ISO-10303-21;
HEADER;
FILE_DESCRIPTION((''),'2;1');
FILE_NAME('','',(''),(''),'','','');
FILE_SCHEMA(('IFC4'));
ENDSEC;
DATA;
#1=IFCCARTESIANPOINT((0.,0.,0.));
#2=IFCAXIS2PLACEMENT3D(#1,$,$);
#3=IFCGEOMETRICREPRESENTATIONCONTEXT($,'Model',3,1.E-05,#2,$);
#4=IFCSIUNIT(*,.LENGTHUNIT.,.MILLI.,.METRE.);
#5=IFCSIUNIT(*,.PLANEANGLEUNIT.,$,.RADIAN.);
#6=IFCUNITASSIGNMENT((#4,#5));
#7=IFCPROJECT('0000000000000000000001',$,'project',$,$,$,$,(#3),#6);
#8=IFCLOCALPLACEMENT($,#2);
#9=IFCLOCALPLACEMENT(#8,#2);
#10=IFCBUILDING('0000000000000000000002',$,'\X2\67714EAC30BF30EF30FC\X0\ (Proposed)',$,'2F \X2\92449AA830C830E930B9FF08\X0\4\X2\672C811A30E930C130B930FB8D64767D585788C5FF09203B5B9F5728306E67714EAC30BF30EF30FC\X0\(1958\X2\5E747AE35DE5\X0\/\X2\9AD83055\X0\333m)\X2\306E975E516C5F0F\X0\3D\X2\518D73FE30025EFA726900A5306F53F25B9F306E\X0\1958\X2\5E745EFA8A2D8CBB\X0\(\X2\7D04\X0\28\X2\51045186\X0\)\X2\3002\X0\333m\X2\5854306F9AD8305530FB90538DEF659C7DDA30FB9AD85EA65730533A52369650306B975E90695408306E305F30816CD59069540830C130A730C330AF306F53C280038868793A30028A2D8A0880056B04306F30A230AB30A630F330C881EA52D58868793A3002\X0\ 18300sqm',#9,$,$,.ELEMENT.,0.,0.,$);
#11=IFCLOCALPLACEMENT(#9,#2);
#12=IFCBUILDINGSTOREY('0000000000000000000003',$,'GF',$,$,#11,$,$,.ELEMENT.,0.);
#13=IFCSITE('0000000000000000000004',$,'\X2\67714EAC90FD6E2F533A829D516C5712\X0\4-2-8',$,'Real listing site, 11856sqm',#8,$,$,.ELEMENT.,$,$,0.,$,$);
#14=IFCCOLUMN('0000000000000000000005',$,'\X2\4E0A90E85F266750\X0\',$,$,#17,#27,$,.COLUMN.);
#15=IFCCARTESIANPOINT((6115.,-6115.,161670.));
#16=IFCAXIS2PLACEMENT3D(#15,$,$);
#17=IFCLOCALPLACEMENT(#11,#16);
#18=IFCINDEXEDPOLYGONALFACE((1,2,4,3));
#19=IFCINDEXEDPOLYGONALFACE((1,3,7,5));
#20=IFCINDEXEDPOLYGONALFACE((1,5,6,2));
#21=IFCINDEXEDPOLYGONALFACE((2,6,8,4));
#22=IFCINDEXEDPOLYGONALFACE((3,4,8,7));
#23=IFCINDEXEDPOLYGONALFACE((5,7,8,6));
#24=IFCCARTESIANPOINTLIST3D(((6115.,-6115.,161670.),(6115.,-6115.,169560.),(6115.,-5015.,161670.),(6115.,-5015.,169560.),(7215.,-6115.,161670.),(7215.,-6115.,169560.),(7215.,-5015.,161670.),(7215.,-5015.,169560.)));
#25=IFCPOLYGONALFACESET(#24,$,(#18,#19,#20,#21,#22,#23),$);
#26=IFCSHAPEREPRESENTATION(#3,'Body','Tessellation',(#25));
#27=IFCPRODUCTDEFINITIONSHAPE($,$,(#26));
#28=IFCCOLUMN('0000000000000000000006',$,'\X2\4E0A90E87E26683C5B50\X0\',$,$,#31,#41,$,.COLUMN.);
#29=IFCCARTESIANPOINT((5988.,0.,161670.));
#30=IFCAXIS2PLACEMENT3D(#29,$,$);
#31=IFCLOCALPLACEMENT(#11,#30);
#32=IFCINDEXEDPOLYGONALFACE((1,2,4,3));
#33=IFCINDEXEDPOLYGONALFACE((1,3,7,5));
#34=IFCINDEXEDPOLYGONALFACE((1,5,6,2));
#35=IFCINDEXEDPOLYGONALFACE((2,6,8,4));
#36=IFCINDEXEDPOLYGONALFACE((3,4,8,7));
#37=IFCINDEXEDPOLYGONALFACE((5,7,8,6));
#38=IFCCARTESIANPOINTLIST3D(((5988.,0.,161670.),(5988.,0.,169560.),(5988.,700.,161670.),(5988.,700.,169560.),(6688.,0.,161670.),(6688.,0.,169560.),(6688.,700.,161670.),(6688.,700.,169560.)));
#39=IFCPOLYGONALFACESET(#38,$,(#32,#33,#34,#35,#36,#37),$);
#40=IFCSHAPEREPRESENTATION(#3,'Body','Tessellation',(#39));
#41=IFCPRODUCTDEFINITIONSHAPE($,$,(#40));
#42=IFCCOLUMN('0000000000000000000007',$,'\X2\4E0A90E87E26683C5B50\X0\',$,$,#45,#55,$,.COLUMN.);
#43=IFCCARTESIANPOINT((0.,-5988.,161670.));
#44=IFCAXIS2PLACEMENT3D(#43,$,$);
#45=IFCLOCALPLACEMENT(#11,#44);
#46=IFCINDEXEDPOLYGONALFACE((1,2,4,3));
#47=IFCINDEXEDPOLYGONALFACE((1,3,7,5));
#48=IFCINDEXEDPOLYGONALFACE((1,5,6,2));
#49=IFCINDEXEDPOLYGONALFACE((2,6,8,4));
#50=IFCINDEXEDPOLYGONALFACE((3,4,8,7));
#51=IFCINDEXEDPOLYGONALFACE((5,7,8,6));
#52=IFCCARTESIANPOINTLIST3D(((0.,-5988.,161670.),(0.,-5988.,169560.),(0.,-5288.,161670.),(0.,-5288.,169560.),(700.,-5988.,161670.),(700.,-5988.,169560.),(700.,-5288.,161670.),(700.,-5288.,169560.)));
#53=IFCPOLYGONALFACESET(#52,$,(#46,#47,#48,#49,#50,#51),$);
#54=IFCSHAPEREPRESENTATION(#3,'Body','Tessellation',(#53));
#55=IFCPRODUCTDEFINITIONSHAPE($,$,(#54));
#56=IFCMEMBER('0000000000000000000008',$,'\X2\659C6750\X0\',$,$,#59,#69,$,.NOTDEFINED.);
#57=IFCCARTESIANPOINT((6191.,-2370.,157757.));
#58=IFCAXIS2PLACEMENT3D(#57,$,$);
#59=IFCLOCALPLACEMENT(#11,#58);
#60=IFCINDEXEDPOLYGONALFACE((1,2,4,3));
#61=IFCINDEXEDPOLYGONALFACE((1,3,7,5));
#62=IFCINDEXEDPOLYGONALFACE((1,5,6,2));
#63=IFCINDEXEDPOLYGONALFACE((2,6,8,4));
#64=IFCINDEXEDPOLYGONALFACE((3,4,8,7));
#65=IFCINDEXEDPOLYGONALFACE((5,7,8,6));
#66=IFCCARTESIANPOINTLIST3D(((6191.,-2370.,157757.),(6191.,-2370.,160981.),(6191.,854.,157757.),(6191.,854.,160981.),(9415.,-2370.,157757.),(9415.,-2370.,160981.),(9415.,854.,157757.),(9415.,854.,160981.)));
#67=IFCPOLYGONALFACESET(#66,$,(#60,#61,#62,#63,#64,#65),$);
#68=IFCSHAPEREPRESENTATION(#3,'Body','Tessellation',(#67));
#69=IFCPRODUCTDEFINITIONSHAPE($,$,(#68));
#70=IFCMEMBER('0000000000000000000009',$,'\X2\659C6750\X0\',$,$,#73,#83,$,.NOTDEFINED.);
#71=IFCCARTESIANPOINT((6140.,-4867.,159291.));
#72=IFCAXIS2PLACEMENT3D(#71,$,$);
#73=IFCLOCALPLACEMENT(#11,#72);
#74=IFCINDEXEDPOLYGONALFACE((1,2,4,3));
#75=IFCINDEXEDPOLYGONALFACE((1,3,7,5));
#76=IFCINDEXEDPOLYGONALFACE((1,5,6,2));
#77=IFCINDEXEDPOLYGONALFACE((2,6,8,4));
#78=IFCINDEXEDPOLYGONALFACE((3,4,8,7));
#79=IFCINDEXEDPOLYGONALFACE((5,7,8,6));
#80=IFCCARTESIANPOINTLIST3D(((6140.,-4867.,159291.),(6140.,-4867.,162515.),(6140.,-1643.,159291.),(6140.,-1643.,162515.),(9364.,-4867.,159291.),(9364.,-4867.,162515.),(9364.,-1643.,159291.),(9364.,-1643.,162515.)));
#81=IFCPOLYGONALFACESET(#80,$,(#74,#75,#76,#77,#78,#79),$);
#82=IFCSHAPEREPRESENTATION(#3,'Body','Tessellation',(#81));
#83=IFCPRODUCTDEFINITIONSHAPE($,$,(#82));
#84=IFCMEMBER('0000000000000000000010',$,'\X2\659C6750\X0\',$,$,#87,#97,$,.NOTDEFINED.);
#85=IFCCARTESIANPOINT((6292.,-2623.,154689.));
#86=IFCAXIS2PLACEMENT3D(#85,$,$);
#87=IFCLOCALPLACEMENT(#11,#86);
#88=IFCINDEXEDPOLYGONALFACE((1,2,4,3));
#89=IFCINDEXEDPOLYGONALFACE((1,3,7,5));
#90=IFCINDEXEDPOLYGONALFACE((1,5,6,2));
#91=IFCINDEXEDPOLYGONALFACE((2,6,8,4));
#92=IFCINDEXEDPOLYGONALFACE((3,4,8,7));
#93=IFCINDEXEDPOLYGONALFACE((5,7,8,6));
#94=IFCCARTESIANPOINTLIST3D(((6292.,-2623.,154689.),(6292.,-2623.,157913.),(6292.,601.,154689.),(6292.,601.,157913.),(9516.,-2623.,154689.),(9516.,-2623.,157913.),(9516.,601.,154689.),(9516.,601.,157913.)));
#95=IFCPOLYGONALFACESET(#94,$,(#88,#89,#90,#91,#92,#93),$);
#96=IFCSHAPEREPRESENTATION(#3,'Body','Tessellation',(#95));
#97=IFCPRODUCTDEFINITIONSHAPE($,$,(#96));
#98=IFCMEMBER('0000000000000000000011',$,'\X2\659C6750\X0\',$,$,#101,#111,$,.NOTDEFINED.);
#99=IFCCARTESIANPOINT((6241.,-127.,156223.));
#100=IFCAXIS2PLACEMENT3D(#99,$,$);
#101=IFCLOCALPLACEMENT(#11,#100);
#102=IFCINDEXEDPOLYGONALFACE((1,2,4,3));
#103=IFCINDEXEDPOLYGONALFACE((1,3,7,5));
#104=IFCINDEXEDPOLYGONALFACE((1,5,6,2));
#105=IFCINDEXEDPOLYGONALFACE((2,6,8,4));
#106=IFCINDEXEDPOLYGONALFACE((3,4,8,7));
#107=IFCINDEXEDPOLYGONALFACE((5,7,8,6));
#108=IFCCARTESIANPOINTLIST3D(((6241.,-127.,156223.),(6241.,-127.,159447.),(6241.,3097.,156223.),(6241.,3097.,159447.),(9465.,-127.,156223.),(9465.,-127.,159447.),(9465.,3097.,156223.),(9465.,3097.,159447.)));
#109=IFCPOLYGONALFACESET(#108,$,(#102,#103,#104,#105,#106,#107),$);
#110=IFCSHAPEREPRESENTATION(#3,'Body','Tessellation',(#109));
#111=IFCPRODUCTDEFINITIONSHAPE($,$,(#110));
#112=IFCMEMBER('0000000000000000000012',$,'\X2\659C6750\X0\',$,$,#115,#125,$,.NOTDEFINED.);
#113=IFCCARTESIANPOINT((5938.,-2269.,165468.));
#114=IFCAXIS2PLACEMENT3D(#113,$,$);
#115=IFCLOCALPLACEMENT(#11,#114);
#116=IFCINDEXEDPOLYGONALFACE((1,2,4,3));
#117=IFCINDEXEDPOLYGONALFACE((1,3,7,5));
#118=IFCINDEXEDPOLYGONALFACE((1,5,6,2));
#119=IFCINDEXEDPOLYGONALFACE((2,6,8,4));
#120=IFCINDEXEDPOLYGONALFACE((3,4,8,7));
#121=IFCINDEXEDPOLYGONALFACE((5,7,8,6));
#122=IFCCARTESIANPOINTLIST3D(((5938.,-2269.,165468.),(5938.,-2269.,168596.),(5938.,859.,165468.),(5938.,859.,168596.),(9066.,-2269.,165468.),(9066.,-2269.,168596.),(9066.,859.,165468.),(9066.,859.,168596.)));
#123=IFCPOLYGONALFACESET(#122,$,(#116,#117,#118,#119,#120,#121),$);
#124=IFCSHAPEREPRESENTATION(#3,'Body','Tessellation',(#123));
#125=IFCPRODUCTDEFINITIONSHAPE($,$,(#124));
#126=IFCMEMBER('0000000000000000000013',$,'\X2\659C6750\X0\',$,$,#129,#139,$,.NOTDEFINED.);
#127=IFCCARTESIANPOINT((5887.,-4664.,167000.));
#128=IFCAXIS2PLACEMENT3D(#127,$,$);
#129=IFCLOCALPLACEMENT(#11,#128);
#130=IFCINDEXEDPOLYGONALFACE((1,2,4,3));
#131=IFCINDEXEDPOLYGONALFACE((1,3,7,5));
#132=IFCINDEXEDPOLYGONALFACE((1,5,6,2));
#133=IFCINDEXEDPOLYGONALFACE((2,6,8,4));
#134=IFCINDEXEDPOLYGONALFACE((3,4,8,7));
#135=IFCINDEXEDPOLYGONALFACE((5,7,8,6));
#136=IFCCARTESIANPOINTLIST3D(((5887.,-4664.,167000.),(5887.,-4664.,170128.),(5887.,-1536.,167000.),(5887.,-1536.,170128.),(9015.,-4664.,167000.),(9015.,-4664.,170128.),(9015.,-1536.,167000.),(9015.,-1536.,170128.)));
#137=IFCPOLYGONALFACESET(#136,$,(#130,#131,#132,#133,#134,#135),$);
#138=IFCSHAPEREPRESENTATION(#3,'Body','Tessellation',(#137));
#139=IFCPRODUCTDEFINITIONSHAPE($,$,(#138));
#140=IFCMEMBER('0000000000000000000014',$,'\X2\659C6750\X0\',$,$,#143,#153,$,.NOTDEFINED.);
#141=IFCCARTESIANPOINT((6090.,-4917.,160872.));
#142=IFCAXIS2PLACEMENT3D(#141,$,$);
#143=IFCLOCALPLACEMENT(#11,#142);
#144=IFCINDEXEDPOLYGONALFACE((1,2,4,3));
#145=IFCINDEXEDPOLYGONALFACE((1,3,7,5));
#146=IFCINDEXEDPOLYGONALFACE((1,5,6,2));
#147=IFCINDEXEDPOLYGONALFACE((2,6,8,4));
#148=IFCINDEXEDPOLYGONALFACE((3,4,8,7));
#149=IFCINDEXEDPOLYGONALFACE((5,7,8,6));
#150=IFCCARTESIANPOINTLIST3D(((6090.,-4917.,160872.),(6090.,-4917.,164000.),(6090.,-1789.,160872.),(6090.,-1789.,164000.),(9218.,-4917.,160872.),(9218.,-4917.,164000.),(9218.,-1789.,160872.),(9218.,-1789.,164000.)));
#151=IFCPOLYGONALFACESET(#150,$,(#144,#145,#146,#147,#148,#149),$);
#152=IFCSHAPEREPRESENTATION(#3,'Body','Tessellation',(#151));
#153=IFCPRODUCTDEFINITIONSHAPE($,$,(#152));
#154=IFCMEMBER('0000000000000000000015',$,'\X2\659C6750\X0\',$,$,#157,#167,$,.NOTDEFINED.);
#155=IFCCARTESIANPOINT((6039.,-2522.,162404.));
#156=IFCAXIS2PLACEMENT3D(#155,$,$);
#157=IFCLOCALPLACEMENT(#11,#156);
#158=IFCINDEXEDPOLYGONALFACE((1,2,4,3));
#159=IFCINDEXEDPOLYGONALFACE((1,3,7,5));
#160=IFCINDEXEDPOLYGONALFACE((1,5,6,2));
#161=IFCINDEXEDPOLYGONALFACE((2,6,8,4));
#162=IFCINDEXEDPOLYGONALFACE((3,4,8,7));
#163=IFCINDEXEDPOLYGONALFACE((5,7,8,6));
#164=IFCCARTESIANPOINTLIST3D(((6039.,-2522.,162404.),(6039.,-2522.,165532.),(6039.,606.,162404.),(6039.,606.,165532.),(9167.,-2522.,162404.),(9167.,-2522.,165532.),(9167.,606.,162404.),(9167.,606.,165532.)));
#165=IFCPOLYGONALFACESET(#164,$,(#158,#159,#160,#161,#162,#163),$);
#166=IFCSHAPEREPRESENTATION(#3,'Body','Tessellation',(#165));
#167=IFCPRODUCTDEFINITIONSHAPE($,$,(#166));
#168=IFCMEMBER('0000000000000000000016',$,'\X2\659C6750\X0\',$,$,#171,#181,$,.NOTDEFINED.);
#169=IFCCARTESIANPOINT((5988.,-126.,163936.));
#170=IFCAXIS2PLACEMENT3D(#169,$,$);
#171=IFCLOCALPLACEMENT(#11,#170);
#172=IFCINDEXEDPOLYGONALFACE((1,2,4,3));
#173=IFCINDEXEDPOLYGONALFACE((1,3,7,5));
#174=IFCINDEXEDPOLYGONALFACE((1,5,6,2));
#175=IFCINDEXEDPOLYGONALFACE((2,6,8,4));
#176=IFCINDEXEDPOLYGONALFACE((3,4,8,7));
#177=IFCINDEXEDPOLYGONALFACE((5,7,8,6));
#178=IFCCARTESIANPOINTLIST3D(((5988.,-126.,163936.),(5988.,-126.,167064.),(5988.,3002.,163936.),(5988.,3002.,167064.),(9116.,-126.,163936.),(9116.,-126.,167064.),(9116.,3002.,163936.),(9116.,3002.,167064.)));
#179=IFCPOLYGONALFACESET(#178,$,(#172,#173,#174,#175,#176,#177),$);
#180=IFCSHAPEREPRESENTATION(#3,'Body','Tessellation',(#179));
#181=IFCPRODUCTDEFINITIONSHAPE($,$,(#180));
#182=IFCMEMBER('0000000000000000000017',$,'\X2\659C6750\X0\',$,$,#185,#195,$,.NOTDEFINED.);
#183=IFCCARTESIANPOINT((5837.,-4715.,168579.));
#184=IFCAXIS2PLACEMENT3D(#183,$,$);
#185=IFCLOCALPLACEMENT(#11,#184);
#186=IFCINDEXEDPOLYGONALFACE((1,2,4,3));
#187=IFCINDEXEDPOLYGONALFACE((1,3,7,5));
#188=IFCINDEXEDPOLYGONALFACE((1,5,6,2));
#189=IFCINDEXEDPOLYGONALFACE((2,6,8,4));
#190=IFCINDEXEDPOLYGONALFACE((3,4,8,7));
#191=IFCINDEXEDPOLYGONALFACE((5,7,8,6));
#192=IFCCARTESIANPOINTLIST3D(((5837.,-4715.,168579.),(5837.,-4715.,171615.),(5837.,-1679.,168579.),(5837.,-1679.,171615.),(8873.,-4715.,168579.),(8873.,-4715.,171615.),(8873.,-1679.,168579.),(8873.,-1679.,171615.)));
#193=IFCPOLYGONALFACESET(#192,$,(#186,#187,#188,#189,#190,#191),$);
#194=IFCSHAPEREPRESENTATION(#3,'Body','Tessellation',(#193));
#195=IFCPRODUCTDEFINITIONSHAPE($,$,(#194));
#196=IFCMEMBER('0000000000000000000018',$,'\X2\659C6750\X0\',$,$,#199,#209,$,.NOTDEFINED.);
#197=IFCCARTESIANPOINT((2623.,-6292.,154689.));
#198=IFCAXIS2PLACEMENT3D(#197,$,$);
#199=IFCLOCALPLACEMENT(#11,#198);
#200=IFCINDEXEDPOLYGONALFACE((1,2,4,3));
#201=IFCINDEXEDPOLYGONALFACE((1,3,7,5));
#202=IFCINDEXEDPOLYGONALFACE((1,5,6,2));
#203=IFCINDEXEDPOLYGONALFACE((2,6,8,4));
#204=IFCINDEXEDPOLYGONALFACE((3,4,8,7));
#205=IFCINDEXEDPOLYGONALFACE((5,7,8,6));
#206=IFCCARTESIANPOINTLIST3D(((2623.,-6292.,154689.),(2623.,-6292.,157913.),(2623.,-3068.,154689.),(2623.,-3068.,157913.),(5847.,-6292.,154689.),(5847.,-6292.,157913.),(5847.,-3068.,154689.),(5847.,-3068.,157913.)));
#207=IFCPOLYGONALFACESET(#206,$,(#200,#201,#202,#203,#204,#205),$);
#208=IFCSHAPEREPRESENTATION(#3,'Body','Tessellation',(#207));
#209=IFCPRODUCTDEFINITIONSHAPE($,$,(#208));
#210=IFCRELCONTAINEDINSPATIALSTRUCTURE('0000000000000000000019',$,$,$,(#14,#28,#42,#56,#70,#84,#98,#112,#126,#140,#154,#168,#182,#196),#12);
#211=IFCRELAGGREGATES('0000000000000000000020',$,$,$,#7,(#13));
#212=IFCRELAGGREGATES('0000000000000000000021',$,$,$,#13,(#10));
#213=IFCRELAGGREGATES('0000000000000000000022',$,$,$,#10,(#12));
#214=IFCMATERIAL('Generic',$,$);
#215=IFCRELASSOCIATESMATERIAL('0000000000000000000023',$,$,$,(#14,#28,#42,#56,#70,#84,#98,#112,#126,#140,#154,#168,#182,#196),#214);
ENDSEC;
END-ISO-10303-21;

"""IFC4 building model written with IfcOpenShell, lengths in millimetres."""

from ifc_helpers import new_model, si_unit, frame, frame_2d, origin, place, context, project, spatial, rectangle, extrude, material, element, save


model = new_model("IFC4")

# Units and contexts
model_context = context("Model", 3, precision=1e-05, world=origin())
ifc_project = project(units=[si_unit("LENGTHUNIT", "METRE", prefix="MILLI"), si_unit("PLANEANGLEUNIT", "RADIAN")], contexts=[model_context])

# Site, building, storey
site_placement = place(None, origin())
site = spatial("IfcSite", under=ifc_project, at=site_placement, Name="東京都港区芝公園4-2-8", ObjectType="Real listing site, 11856sqm", CompositionType="ELEMENT", RefElevation=0.0)
building_placement = place(site_placement, origin())
building = spatial("IfcBuilding", under=site, at=building_placement, Name="東京タワー (Proposed)", ObjectType="2F 鉄骨トラス（4本脚ラチス・赤白塗装）※実在の東京タワー(1958年竣工/高さ333m)の非公式3D再現。建物¥は史実の1958年建設費(約28億円)。333m塔は高さ・道路斜線・高度地区制限に非適合のため法適合チェックは参考表示。設計者欄はアカウント自動表示。 18300sqm", CompositionType="ELEMENT", ElevationOfRefHeight=0.0, ElevationOfTerrain=0.0)
storey_placement = place(building_placement, origin())
storey = spatial("IfcBuildingStorey", under=building, at=storey_placement, Name="GF", CompositionType="ELEMENT", Elevation=0.0)

# Columns
ifc_material = material(Name="Generic")
column_1_placement = place(storey_placement, frame((6115.0, -6115.0, 161670.0)))
element("IfcColumn", 1, at=column_1_placement, inside=storey, material=ifc_material, Name="上部弦材", PredefinedType="COLUMN", context=model_context, shape_type="SweptSolid", body=[
    extrude(rectangle(XDim=1100.0, YDim=1100.0, at=frame_2d((550.0, 550.0))), frame((6115.0, -6115.0, 161670.0)), (0.0, 0.0, 1.0), 7890.0),
])
column_2_placement = place(storey_placement, frame((5988.0, 0.0, 161670.0)))
element("IfcColumn", 2, at=column_2_placement, inside=storey, material=ifc_material, Name="上部縦格子", PredefinedType="COLUMN", context=model_context, shape_type="SweptSolid", body=[
    extrude(rectangle(XDim=700.0, YDim=700.0, at=frame_2d((350.0, 350.0))), frame((5988.0, 0.0, 161670.0)), (0.0, 0.0, 1.0), 7890.0),
])
column_3_placement = place(storey_placement, frame((0.0, -5988.0, 161670.0)))
element("IfcColumn", 3, at=column_3_placement, inside=storey, material=ifc_material, Name="上部縦格子", PredefinedType="COLUMN", context=model_context, shape_type="SweptSolid", body=[
    extrude(rectangle(XDim=700.0, YDim=700.0, at=frame_2d((350.0, 350.0))), frame((0.0, -5988.0, 161670.0)), (0.0, 0.0, 1.0), 7890.0),
])

# Members
member_1_placement = place(storey_placement, frame((6191.0, -2370.0, 157757.0)))
element("IfcMember", 4, at=member_1_placement, inside=storey, material=ifc_material, Name="斜材", PredefinedType="NOTDEFINED", context=model_context, shape_type="SweptSolid", body=[
    extrude(rectangle(XDim=3224.0, YDim=3224.0, at=frame_2d((1612.0, 1612.0))), frame((6191.0, -2370.0, 157757.0)), (0.0, 0.0, 1.0), 3224.0),
])
member_2_placement = place(storey_placement, frame((6140.0, -4867.0, 159291.0)))
element("IfcMember", 5, at=member_2_placement, inside=storey, material=ifc_material, Name="斜材", PredefinedType="NOTDEFINED", context=model_context, shape_type="SweptSolid", body=[
    extrude(rectangle(XDim=3224.0, YDim=3224.0, at=frame_2d((1612.0, 1612.0))), frame((6140.0, -4867.0, 159291.0)), (0.0, 0.0, 1.0), 3224.0),
])
member_3_placement = place(storey_placement, frame((6292.0, -2623.0, 154689.0)))
element("IfcMember", 6, at=member_3_placement, inside=storey, material=ifc_material, Name="斜材", PredefinedType="NOTDEFINED", context=model_context, shape_type="SweptSolid", body=[
    extrude(rectangle(XDim=3224.0, YDim=3224.0, at=frame_2d((1612.0, 1612.0))), frame((6292.0, -2623.0, 154689.0)), (0.0, 0.0, 1.0), 3224.0),
])
member_4_placement = place(storey_placement, frame((6241.0, -127.0, 156223.0)))
element("IfcMember", 7, at=member_4_placement, inside=storey, material=ifc_material, Name="斜材", PredefinedType="NOTDEFINED", context=model_context, shape_type="SweptSolid", body=[
    extrude(rectangle(XDim=3224.0, YDim=3224.0, at=frame_2d((1612.0, 1612.0))), frame((6241.0, -127.0, 156223.0)), (0.0, 0.0, 1.0), 3224.0),
])
member_5_placement = place(storey_placement, frame((5938.0, -2269.0, 165468.0)))
element("IfcMember", 8, at=member_5_placement, inside=storey, material=ifc_material, Name="斜材", PredefinedType="NOTDEFINED", context=model_context, shape_type="SweptSolid", body=[
    extrude(rectangle(XDim=3128.0, YDim=3128.0, at=frame_2d((1564.0, 1564.0))), frame((5938.0, -2269.0, 165468.0)), (0.0, 0.0, 1.0), 3128.0),
])
member_6_placement = place(storey_placement, frame((5887.0, -4664.0, 167000.0)))
element("IfcMember", 9, at=member_6_placement, inside=storey, material=ifc_material, Name="斜材", PredefinedType="NOTDEFINED", context=model_context, shape_type="SweptSolid", body=[
    extrude(rectangle(XDim=3128.0, YDim=3128.0, at=frame_2d((1564.0, 1564.0))), frame((5887.0, -4664.0, 167000.0)), (0.0, 0.0, 1.0), 3128.0),
])
member_7_placement = place(storey_placement, frame((6090.0, -4917.0, 160872.0)))
element("IfcMember", 10, at=member_7_placement, inside=storey, material=ifc_material, Name="斜材", PredefinedType="NOTDEFINED", context=model_context, shape_type="SweptSolid", body=[
    extrude(rectangle(XDim=3128.0, YDim=3128.0, at=frame_2d((1564.0, 1564.0))), frame((6090.0, -4917.0, 160872.0)), (0.0, 0.0, 1.0), 3128.0),
])
member_8_placement = place(storey_placement, frame((6039.0, -2522.0, 162404.0)))
element("IfcMember", 11, at=member_8_placement, inside=storey, material=ifc_material, Name="斜材", PredefinedType="NOTDEFINED", context=model_context, shape_type="SweptSolid", body=[
    extrude(rectangle(XDim=3128.0, YDim=3128.0, at=frame_2d((1564.0, 1564.0))), frame((6039.0, -2522.0, 162404.0)), (0.0, 0.0, 1.0), 3128.0),
])
member_9_placement = place(storey_placement, frame((5988.0, -126.0, 163936.0)))
element("IfcMember", 12, at=member_9_placement, inside=storey, material=ifc_material, Name="斜材", PredefinedType="NOTDEFINED", context=model_context, shape_type="SweptSolid", body=[
    extrude(rectangle(XDim=3128.0, YDim=3128.0, at=frame_2d((1564.0, 1564.0))), frame((5988.0, -126.0, 163936.0)), (0.0, 0.0, 1.0), 3128.0),
])
member_10_placement = place(storey_placement, frame((5837.0, -4715.0, 168579.0)))
element("IfcMember", 13, at=member_10_placement, inside=storey, material=ifc_material, Name="斜材", PredefinedType="NOTDEFINED", context=model_context, shape_type="SweptSolid", body=[
    extrude(rectangle(XDim=3036.0, YDim=3036.0, at=frame_2d((1518.0, 1518.0))), frame((5837.0, -4715.0, 168579.0)), (0.0, 0.0, 1.0), 3036.0),
])
member_11_placement = place(storey_placement, frame((2623.0, -6292.0, 154689.0)))
element("IfcMember", 14, at=member_11_placement, inside=storey, material=ifc_material, Name="斜材", PredefinedType="NOTDEFINED", context=model_context, shape_type="SweptSolid", body=[
    extrude(rectangle(XDim=3224.0, YDim=3224.0, at=frame_2d((1612.0, 1612.0))), frame((2623.0, -6292.0, 154689.0)), (0.0, 0.0, 1.0), 3224.0),
])

save(model, "model.ifc")
